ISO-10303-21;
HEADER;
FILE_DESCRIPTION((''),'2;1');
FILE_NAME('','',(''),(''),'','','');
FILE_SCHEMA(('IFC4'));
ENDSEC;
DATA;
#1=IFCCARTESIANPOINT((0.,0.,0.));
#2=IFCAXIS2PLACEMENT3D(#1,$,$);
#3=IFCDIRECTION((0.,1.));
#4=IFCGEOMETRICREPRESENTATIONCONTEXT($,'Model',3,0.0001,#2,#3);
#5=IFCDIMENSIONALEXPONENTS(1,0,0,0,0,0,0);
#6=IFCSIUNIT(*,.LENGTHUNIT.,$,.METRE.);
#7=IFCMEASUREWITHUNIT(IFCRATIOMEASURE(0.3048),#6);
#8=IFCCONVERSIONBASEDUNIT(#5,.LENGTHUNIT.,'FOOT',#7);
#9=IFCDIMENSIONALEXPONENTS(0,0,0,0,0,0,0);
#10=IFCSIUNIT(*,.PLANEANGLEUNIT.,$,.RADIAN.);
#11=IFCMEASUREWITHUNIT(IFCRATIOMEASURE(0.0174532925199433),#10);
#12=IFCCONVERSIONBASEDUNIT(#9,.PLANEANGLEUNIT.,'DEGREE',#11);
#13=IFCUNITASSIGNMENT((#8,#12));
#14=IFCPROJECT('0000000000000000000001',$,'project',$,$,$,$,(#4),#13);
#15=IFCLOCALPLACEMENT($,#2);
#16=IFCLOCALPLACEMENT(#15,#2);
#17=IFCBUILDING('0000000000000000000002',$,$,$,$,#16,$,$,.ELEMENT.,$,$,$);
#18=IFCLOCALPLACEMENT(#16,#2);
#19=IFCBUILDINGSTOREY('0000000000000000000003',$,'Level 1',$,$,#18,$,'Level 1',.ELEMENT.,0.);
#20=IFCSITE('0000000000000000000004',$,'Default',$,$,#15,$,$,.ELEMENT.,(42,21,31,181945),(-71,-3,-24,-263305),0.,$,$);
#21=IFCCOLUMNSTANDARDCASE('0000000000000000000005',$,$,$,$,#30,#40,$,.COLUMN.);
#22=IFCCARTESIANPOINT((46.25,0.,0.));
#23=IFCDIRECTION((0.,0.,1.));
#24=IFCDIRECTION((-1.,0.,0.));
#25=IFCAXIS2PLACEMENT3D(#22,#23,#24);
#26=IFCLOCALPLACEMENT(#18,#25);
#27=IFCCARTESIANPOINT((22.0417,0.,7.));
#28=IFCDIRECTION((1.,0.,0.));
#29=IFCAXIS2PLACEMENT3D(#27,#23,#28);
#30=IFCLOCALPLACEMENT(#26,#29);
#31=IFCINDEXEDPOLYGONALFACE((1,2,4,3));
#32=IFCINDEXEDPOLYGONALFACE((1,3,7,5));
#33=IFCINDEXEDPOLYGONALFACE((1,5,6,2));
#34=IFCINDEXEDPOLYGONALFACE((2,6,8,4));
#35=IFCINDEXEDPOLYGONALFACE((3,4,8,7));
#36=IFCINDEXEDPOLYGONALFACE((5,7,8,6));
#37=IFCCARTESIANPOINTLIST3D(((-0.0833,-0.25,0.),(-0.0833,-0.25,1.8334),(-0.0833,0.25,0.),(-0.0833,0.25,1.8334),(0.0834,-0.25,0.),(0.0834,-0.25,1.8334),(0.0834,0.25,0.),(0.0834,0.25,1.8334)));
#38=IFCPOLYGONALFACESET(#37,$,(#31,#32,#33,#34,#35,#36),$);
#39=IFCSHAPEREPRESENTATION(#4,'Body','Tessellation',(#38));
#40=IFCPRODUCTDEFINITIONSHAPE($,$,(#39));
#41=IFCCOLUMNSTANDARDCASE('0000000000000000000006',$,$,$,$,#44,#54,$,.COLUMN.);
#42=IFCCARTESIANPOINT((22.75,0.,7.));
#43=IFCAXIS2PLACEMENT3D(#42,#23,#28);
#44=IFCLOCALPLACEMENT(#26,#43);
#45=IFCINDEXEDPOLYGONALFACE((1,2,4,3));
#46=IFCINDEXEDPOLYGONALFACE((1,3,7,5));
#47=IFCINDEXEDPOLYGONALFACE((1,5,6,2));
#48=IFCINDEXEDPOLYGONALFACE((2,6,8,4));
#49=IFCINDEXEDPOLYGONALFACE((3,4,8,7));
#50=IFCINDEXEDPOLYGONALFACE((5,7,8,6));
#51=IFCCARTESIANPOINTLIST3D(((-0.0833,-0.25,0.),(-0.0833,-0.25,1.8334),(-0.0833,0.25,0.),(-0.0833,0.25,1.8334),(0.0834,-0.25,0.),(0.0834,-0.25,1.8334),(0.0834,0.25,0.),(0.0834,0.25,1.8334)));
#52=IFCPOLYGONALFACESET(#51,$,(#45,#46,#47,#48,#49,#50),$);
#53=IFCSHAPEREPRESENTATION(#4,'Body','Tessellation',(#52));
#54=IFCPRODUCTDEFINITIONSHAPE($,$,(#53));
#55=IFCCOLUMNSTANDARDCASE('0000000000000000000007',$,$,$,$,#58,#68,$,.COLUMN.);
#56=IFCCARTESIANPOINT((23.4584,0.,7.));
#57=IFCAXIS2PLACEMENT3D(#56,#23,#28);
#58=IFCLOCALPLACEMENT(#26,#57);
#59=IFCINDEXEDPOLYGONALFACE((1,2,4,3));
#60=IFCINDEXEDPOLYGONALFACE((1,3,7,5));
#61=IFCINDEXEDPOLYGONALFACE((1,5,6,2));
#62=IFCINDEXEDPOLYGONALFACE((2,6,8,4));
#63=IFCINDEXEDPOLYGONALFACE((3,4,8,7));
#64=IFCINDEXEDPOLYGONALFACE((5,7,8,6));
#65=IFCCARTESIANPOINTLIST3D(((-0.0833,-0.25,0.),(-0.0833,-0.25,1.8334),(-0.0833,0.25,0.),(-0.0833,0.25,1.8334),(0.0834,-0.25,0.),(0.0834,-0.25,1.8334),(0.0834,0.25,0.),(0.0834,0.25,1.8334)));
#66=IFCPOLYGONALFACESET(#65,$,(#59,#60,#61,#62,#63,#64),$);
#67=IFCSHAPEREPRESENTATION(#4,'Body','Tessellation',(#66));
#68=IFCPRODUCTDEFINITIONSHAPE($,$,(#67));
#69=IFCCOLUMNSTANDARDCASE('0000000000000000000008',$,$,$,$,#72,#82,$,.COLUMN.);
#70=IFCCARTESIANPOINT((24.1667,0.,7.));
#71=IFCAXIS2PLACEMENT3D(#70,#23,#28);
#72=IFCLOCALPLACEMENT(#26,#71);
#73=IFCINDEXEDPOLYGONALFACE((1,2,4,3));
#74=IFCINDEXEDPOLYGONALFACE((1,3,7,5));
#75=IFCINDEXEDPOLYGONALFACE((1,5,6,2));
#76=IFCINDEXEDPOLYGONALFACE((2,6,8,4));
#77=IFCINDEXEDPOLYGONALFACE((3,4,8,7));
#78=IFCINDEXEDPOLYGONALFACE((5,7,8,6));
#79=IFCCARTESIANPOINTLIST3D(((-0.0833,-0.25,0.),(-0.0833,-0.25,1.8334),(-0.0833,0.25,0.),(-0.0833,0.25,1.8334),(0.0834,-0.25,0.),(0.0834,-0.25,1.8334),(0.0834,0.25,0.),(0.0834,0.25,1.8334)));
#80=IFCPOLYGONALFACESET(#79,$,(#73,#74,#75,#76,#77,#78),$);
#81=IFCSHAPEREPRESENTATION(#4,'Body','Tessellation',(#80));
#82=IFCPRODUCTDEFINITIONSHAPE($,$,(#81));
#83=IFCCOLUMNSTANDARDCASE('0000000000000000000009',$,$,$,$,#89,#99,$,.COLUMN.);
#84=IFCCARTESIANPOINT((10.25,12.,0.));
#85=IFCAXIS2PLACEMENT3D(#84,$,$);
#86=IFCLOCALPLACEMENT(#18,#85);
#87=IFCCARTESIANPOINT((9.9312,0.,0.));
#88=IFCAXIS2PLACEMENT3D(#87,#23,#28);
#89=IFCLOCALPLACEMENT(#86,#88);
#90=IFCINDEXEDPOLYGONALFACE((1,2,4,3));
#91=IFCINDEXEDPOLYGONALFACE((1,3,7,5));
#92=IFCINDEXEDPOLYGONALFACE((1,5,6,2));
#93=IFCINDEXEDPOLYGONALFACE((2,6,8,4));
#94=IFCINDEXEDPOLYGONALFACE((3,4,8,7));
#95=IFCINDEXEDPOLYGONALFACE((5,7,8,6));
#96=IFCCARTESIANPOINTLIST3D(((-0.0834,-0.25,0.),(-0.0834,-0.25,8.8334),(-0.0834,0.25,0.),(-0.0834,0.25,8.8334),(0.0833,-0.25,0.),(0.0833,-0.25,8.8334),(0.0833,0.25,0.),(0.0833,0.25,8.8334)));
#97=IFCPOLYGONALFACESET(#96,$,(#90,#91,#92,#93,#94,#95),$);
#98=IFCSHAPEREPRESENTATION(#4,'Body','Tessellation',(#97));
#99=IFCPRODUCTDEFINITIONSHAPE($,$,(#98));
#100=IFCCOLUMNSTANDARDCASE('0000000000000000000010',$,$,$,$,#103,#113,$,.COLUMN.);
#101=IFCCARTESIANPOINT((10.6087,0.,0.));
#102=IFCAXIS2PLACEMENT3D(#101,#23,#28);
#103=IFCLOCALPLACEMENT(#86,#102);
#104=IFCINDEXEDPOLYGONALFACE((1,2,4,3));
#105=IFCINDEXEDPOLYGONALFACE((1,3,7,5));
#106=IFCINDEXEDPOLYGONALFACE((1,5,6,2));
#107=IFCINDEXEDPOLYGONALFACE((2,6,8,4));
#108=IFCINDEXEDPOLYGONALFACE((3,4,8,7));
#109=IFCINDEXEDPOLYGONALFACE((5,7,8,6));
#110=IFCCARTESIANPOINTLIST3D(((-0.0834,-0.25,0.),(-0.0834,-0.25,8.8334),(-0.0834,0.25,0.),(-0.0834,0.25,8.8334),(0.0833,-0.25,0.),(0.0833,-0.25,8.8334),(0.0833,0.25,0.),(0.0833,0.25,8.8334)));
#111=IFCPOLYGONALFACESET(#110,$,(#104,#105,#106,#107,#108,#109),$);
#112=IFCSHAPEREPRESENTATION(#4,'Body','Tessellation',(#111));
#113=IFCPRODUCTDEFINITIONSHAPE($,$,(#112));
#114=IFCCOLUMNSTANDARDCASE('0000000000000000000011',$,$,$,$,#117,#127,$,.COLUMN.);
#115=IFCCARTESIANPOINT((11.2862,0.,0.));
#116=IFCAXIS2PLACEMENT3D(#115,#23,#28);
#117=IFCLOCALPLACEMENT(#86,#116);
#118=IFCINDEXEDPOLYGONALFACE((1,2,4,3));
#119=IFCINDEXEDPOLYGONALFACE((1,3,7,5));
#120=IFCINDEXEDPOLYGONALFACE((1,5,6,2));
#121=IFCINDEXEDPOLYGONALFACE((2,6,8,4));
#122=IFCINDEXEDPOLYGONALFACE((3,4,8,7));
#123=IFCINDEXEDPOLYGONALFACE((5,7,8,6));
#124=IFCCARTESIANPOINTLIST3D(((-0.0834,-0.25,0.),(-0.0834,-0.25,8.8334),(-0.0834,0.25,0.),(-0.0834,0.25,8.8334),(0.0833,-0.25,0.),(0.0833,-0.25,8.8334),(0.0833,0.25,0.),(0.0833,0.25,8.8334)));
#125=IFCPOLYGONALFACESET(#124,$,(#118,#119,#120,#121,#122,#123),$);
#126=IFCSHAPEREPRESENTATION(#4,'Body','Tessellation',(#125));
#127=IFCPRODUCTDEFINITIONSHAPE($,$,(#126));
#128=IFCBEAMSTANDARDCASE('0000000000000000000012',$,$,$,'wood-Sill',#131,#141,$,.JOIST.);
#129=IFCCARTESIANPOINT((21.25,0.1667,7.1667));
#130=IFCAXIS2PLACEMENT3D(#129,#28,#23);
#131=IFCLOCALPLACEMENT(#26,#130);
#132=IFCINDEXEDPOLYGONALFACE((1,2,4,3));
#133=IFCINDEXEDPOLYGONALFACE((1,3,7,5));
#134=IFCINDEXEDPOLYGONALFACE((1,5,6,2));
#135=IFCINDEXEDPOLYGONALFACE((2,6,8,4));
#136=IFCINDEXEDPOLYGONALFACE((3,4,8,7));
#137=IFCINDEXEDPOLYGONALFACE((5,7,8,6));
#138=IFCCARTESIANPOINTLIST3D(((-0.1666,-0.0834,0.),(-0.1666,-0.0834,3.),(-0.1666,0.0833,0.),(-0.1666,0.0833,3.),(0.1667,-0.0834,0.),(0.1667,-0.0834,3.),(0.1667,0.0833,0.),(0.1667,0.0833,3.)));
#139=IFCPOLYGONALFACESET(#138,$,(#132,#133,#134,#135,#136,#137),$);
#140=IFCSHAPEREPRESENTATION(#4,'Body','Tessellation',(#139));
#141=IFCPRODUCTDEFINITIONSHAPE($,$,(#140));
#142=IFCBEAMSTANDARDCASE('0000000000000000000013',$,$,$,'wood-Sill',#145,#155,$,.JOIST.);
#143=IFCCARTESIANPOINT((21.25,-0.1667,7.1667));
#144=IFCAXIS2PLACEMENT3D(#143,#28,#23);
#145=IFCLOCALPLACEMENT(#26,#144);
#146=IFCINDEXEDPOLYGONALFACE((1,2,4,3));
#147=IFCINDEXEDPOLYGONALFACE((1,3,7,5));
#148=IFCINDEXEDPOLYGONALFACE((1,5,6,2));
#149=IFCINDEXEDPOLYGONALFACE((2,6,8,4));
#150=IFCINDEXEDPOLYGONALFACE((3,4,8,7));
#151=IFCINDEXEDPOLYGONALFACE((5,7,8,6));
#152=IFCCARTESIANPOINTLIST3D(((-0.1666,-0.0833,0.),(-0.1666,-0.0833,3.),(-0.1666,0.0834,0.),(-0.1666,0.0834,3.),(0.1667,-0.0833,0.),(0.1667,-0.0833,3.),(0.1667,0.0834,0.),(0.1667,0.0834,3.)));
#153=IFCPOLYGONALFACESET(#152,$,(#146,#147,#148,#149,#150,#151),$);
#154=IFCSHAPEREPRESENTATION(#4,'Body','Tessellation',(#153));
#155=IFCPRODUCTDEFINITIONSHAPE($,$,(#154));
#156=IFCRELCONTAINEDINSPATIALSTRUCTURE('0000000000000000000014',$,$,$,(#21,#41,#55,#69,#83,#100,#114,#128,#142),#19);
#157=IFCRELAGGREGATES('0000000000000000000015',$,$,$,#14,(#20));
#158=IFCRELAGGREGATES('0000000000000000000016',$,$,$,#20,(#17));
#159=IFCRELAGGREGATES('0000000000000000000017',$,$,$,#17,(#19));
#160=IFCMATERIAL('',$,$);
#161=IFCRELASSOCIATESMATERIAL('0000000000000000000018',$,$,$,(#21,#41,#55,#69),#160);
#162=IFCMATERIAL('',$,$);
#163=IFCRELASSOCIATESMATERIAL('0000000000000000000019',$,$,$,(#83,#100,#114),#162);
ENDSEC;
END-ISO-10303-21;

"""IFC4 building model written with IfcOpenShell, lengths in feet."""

from ifc_helpers import new_model, entity, si_unit, converted_unit, direction, frame, origin, origin_with_axes, place, context, project, spatial, rectangle, extrude, material, element, save


model = new_model("IFC4")

# Units and contexts
model_context = context("Model", 3, precision=0.0001, world=origin(), true_north=direction((0.0, 1.0)))
ifc_project = project(units=[converted_unit("LENGTHUNIT", "FOOT", entity("IfcRatioMeasure", 0.3048), si_unit("LENGTHUNIT", "METRE"), dimensions=[1, 0, 0, 0, 0, 0, 0]), converted_unit("PLANEANGLEUNIT", "DEGREE", entity("IfcRatioMeasure", 0.0174532925199433), si_unit("PLANEANGLEUNIT", "RADIAN"), dimensions=[0, 0, 0, 0, 0, 0, 0])], contexts=[model_context])

# Site, building, storey
site_placement = place(None, origin())
site = spatial("IfcSite", under=ifc_project, at=site_placement, Name="Default", CompositionType="ELEMENT", RefLatitude=(42, 21, 31, 181945), RefLongitude=(-71, -3, -24, -263305), RefElevation=0.0)
building_placement = place(site_placement, origin())
building = spatial("IfcBuilding", under=site, at=building_placement, CompositionType="ELEMENT")
storey_placement = place(building_placement, origin())
storey = spatial("IfcBuildingStorey", under=building, at=storey_placement, Name="Level 1", LongName="Level 1", CompositionType="ELEMENT", Elevation=0.0)

# Columns
placement_1 = place(storey_placement, frame((46.25, 0.0, 0.0), z_axis=(0.0, 0.0, 1.0), x_axis=(-1.0, 0.0, 0.0)))
ifc_material_1 = material(Name="")
for number, where, z_axis, x_axis in (
    (1, (22.0417, 0.0, 7.0), (0.0, 0.0, 1.0), (1.0, 0.0, 0.0)),
    (2, (22.75, 0.0, 7.0), (0.0, 0.0, 1.0), (1.0, 0.0, 0.0)),
    (3, (23.4584, 0.0, 7.0), (0.0, 0.0, 1.0), (1.0, 0.0, 0.0)),
    (4, (24.1667, 0.0, 7.0), (0.0, 0.0, 1.0), (1.0, 0.0, 0.0)),
):
    element("IfcColumnStandardCase", number, at=place(placement_1, frame(where, z_axis=z_axis, x_axis=x_axis)), inside=storey, material=ifc_material_1, PredefinedType="COLUMN", context=model_context, shape_type="SweptSolid", body=[
        extrude(rectangle(XDim=0.1667, YDim=0.5), origin(), (0.0, 0.0, 1.0), 1.8334),
    ])
ifc_material_2 = material(Name="")
placement_2 = place(storey_placement, frame((10.25, 12.0, 0.0)))
for number, where, z_axis, x_axis in (
    (5, (9.9312, 0.0, 0.0), (0.0, 0.0, 1.0), (1.0, 0.0, 0.0)),
    (6, (10.6087, 0.0, 0.0), (0.0, 0.0, 1.0), (1.0, 0.0, 0.0)),
    (7, (11.2862, 0.0, 0.0), (0.0, 0.0, 1.0), (1.0, 0.0, 0.0)),
):
    element("IfcColumnStandardCase", number, at=place(placement_2, frame(where, z_axis=z_axis, x_axis=x_axis)), inside=storey, material=ifc_material_2, PredefinedType="COLUMN", context=model_context, shape_type="SweptSolid", body=[
        extrude(rectangle(XDim=0.1667, YDim=0.5), origin(), (0.0, 0.0, 1.0), 8.8334),
    ])

# Beams
for number, where, z_axis, x_axis in (
    (8, (21.25, 0.1667, 7.1667), (1.0, 0.0, 0.0), (0.0, 0.0, 1.0)),
    (9, (21.25, -0.1667, 7.1667), (1.0, 0.0, 0.0), (0.0, 0.0, 1.0)),
):
    element("IfcBeamStandardCase", number, at=place(placement_1, frame(where, z_axis=z_axis, x_axis=x_axis)), inside=storey, ObjectType="wood-Sill", PredefinedType="JOIST", context=model_context, shape_type="SweptSolid", body=[
        extrude(rectangle(XDim=0.3333, YDim=0.1667), origin_with_axes(), (0.0, 0.0, 1.0), 3.0),
    ])

save(model, "model.ifc")
